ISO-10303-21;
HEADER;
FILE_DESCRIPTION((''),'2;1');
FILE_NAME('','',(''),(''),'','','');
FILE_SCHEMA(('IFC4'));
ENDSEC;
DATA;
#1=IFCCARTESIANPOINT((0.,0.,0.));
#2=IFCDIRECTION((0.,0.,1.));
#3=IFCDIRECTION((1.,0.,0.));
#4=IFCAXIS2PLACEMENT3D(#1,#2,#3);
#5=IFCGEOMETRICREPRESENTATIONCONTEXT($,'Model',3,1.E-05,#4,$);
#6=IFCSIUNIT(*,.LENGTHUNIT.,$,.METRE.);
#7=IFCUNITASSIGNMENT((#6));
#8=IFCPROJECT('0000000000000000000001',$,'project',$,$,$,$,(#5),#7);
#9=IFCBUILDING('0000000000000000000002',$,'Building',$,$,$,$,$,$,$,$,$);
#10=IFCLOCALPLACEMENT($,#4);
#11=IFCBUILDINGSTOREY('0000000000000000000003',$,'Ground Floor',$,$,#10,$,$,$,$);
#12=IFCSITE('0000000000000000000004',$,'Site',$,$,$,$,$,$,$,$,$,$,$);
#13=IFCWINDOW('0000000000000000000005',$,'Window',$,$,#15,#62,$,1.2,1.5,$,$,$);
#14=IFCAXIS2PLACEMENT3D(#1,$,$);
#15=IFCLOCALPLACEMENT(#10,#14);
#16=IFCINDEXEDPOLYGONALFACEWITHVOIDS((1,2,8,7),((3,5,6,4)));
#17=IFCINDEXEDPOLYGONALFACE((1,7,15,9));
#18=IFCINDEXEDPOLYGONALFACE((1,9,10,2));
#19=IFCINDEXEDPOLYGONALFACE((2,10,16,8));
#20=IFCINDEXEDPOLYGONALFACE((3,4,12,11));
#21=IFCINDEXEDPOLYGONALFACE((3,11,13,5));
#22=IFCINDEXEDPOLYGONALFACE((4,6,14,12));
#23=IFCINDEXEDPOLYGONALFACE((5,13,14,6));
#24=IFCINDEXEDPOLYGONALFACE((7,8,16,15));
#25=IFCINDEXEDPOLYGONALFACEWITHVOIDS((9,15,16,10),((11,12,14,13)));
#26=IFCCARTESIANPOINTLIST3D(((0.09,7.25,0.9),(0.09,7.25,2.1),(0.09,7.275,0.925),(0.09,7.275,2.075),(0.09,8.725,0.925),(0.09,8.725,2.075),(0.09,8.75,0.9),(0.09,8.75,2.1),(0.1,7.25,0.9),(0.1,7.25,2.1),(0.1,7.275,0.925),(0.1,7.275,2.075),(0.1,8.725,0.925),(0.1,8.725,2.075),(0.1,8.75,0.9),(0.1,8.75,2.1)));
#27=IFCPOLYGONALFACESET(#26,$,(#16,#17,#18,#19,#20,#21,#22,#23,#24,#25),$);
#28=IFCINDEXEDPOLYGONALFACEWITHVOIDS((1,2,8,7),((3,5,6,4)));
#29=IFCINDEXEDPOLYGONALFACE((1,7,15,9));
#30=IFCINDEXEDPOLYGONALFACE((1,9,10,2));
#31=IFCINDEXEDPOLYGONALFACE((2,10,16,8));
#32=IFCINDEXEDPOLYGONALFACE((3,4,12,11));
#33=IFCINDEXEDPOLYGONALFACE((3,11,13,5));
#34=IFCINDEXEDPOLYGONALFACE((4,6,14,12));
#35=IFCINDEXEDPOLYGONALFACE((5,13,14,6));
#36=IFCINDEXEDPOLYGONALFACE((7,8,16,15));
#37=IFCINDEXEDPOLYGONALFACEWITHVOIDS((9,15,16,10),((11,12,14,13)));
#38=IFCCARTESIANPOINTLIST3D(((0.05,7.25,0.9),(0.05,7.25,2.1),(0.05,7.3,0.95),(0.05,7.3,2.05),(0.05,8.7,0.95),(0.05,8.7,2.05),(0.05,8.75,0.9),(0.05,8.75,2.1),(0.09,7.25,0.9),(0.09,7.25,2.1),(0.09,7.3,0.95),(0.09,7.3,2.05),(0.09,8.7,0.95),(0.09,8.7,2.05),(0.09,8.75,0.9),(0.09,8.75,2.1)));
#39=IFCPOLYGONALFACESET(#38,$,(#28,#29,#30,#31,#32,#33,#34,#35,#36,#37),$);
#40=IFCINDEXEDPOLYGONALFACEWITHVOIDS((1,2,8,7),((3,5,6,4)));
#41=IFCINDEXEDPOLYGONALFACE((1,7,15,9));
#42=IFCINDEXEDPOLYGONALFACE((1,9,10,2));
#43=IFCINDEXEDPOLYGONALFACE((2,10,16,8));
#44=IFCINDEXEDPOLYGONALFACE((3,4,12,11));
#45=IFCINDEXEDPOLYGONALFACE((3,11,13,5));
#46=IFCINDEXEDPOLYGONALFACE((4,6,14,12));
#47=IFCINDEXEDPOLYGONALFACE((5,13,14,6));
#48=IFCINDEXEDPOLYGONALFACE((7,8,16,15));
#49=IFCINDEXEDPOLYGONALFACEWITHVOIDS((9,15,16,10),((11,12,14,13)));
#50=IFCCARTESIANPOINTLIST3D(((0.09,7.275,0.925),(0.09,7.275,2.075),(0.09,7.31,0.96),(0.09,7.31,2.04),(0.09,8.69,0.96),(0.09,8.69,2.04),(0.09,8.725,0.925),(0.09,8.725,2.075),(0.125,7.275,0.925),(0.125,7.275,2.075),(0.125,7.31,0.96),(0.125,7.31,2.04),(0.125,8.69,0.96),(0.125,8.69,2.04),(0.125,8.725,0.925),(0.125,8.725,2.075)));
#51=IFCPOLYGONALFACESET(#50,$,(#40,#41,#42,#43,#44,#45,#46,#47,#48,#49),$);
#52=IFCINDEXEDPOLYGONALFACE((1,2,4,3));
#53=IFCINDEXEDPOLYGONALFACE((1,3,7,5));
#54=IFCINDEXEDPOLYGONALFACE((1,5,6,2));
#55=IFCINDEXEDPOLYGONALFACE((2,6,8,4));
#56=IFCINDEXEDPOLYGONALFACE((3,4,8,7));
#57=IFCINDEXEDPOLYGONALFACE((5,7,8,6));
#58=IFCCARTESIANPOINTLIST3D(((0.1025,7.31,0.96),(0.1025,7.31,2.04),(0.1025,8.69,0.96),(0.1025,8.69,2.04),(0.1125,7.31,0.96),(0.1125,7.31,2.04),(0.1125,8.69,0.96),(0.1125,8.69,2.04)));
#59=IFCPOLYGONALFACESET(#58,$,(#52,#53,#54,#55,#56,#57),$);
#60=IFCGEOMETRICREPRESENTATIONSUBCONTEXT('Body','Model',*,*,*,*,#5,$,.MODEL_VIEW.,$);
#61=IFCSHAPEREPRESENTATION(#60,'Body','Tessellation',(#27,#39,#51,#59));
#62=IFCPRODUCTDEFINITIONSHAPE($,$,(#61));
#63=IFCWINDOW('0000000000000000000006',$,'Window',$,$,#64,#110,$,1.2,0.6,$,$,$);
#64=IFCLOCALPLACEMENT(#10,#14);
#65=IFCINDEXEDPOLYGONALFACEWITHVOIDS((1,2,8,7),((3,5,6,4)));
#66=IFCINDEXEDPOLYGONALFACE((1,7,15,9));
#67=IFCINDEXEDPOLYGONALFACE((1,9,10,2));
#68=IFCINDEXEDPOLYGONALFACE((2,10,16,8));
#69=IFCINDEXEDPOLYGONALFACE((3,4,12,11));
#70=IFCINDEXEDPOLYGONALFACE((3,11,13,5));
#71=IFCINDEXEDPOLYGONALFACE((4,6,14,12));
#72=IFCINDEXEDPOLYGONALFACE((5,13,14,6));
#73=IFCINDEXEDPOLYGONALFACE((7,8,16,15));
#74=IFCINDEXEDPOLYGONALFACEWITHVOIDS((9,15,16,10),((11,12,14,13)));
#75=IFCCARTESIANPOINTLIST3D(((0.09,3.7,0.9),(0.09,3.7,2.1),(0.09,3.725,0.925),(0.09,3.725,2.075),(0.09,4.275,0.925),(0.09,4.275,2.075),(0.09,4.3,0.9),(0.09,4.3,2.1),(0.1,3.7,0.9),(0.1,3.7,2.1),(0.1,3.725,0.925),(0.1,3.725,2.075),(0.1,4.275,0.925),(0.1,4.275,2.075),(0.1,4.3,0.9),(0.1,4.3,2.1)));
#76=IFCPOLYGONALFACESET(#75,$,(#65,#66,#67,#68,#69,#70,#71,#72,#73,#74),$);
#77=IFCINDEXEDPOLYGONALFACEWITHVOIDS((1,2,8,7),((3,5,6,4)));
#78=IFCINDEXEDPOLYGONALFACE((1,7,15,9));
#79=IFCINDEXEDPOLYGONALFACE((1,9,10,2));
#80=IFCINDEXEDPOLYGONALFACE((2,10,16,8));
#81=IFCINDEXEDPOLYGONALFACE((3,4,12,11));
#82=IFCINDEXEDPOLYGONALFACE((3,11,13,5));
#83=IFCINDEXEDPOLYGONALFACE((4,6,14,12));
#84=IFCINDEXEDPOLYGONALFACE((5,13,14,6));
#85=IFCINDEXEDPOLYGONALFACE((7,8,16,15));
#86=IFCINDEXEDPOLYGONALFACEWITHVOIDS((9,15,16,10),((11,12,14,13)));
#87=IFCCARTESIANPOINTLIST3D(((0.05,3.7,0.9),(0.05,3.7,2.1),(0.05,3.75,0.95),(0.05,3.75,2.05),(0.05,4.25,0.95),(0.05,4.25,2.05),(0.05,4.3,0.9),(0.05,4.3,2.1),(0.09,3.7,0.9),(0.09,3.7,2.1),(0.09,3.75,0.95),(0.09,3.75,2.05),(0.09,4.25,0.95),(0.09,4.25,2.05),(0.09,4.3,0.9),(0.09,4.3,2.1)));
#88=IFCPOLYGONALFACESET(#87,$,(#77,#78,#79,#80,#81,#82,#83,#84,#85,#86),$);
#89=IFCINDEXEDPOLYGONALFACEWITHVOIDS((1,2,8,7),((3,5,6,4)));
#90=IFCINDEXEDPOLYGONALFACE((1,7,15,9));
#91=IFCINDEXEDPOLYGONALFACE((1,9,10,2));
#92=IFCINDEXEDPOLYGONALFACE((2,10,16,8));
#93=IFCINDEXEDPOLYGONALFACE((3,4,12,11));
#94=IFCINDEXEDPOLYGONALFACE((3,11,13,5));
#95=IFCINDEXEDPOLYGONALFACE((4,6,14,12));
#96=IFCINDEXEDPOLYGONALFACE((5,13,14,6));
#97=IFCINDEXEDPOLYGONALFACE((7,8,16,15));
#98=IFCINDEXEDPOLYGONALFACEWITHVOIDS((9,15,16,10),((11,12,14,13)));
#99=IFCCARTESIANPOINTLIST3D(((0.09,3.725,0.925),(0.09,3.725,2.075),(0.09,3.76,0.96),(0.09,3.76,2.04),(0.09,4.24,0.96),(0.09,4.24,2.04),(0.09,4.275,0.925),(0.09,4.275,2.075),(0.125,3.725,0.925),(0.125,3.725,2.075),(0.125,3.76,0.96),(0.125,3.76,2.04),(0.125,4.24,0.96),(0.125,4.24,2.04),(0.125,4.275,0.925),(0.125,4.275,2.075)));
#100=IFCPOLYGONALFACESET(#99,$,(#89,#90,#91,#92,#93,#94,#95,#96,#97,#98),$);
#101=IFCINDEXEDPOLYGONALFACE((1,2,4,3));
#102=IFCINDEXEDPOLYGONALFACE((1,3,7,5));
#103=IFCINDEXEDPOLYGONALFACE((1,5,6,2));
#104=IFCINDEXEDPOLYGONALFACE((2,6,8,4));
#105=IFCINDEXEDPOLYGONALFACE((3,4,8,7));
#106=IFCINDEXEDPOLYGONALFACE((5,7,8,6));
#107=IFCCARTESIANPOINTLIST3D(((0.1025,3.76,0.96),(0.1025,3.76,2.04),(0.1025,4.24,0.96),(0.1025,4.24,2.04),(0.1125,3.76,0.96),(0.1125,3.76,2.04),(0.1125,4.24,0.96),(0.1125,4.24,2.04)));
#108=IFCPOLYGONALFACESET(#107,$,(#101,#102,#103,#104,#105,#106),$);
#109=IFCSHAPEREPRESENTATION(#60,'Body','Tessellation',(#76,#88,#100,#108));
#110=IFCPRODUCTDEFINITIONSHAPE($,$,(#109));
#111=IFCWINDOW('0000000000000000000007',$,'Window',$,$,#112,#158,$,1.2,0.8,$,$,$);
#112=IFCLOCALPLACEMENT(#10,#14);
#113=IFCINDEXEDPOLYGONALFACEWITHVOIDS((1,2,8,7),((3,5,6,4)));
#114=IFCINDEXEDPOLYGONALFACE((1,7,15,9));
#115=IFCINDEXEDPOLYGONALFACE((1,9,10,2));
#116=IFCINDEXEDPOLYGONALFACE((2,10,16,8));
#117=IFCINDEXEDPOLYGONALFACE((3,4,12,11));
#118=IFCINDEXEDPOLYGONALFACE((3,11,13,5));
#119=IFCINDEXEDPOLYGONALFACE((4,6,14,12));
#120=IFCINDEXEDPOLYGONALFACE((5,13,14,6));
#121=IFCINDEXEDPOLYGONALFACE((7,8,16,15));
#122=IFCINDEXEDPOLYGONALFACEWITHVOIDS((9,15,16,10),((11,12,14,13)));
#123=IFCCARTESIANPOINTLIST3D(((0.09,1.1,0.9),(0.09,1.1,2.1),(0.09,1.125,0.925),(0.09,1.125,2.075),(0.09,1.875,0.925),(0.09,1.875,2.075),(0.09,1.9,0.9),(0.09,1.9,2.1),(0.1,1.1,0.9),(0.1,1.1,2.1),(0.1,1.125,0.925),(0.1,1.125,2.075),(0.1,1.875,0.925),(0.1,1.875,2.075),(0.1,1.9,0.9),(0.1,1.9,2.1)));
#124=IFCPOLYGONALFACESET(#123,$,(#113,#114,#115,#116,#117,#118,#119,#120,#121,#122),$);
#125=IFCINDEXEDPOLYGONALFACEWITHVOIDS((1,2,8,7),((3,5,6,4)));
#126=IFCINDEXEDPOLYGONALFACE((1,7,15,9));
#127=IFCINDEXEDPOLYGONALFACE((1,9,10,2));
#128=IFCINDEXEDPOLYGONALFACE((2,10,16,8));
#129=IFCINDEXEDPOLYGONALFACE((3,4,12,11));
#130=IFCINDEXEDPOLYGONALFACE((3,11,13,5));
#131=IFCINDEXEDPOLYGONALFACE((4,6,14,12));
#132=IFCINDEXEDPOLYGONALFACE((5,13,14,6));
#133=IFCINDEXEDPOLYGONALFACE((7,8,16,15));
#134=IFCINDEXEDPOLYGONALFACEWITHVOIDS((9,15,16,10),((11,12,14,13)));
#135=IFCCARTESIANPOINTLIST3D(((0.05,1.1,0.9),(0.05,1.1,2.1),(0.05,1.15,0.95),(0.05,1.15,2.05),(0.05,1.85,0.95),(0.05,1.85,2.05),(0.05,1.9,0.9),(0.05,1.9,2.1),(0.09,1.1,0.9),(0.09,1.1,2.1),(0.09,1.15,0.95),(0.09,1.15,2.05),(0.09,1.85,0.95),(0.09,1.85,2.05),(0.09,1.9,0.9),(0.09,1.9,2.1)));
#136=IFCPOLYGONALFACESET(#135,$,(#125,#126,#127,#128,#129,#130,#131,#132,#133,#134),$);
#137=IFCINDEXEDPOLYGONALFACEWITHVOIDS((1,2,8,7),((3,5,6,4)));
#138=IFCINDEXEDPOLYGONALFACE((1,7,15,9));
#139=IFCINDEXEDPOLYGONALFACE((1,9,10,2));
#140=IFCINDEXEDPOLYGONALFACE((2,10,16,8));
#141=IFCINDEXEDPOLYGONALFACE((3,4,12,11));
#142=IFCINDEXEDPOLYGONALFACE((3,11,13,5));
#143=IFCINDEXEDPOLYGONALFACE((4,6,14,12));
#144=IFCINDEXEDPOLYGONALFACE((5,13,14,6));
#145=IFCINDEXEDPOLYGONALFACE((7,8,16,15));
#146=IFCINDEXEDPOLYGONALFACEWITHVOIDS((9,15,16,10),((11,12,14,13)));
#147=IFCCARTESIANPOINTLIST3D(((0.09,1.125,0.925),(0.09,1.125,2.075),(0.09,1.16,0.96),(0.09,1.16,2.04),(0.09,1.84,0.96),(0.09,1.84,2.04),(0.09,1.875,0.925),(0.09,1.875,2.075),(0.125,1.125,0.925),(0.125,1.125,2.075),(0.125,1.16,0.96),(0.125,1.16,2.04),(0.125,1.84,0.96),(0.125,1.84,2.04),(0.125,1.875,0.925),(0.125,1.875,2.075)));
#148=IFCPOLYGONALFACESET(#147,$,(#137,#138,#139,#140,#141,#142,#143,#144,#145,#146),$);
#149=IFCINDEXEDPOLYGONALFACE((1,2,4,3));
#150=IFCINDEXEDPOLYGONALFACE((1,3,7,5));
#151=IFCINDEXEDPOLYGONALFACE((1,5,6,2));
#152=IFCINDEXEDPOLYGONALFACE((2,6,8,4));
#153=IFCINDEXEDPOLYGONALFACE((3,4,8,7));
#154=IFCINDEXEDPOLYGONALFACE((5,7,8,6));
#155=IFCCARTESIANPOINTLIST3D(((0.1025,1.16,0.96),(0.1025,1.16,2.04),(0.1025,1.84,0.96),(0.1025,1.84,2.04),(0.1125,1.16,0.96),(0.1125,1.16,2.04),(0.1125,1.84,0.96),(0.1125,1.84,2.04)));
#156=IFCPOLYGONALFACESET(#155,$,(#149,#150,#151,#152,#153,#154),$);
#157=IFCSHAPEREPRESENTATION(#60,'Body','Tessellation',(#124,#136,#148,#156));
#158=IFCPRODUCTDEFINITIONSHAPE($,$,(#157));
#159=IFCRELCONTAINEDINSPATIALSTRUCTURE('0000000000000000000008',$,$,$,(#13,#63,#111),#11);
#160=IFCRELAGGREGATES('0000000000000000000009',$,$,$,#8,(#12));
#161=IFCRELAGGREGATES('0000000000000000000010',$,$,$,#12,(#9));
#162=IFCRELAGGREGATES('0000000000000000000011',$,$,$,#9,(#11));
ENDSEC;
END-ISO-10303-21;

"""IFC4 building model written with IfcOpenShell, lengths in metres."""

from ifc_helpers import new_model, si_unit, frame, origin_with_axes, place, context, subcontext, project, spatial, line, indexed_curve, outline, extrude, element, save


model = new_model("IFC4")

# Units and contexts
model_context = context("Model", 3, precision=1e-05, world=origin_with_axes())
body_context = subcontext(model_context, "Body", "Model", "MODEL_VIEW")
ifc_project = project(units=[si_unit("LENGTHUNIT", "METRE")], contexts=[model_context])

# Site, building, storey
site = spatial("IfcSite", under=ifc_project, Name="Site")
building = spatial("IfcBuilding", under=site, Name="Building")
storey_placement = place(None, origin_with_axes())
storey = spatial("IfcBuildingStorey", under=building, at=storey_placement, Name="Ground Floor")

# Windows
window_1_placement = place(storey_placement, frame((0.0, 8.75, 0.9), z_axis=(0.0, 0.0, 1.0), x_axis=(0.0, -1.0, 0.0)))
element("IfcWindow", 1, at=window_1_placement, inside=storey, Name="Window", OverallHeight=1.2, OverallWidth=1.5, context=body_context, shape_type="SweptSolid", body=[
    extrude(outline(indexed_curve([(0.0, 0.0), (1.5, 0.0), (1.5, 1.2), (0.0, 1.2)], segments=[line(1, 2, 3, 4, 1)]), holes=[indexed_curve([(0.025, 0.025), (1.475, 0.025), (1.475, 1.175), (0.025, 1.175)], segments=[line(1, 2, 3, 4, 1)])]), frame((0.0, 0.09, 0.0), z_axis=(0.0, -1.0, 0.0), x_axis=(1.0, 0.0, 0.0)), (0.0, 0.0, -1.0), 0.01),
    extrude(outline(indexed_curve([(0.0, 0.0), (1.5, 0.0), (1.5, 1.2), (0.0, 1.2)], segments=[line(1, 2, 3, 4, 1)]), holes=[indexed_curve([(0.05, 0.05), (1.45, 0.05), (1.45, 1.15), (0.05, 1.15)], segments=[line(1, 2, 3, 4, 1)])]), frame((0.0, 0.05, 0.0), z_axis=(0.0, -1.0, 0.0), x_axis=(1.0, 0.0, 0.0)), (0.0, 0.0, -1.0), 0.04),
    extrude(outline(indexed_curve([(0.0, 0.0), (1.45, 0.0), (1.45, 1.15), (0.0, 1.15)], segments=[line(1, 2, 3, 4, 1)]), holes=[indexed_curve([(0.035, 0.035), (1.415, 0.035), (1.415, 1.115), (0.035, 1.115)], segments=[line(1, 2, 3, 4, 1)])]), frame((0.025, 0.09, 0.025), z_axis=(0.0, -1.0, 0.0), x_axis=(1.0, 0.0, 0.0)), (0.0, 0.0, -1.0), 0.035),
    extrude(outline(indexed_curve([(0.035, 0.035), (1.415, 0.035), (1.415, 1.115), (0.035, 1.115)], segments=[line(1, 2, 3, 4, 1)])), frame((0.025, 0.1025, 0.025), z_axis=(0.0, -1.0, 0.0), x_axis=(1.0, 0.0, 0.0)), (0.0, 0.0, -1.0), 0.01),
])
window_2_placement = place(storey_placement, frame((0.0, 4.3, 0.9), z_axis=(0.0, 0.0, 1.0), x_axis=(0.0, -1.0, 0.0)))
element("IfcWindow", 2, at=window_2_placement, inside=storey, Name="Window", OverallHeight=1.2, OverallWidth=0.6, context=body_context, shape_type="SweptSolid", body=[
    extrude(outline(indexed_curve([(0.0, 0.0), (0.6, 0.0), (0.6, 1.2), (0.0, 1.2)], segments=[line(1, 2, 3, 4, 1)]), holes=[indexed_curve([(0.025, 0.025), (0.575, 0.025), (0.575, 1.175), (0.025, 1.175)], segments=[line(1, 2, 3, 4, 1)])]), frame((0.0, 0.09, 0.0), z_axis=(0.0, -1.0, 0.0), x_axis=(1.0, 0.0, 0.0)), (0.0, 0.0, -1.0), 0.01),
    extrude(outline(indexed_curve([(0.0, 0.0), (0.6, 0.0), (0.6, 1.2), (0.0, 1.2)], segments=[line(1, 2, 3, 4, 1)]), holes=[indexed_curve([(0.05, 0.05), (0.55, 0.05), (0.55, 1.15), (0.05, 1.15)], segments=[line(1, 2, 3, 4, 1)])]), frame((0.0, 0.05, 0.0), z_axis=(0.0, -1.0, 0.0), x_axis=(1.0, 0.0, 0.0)), (0.0, 0.0, -1.0), 0.04),
    extrude(outline(indexed_curve([(0.0, 0.0), (0.55, 0.0), (0.55, 1.15), (0.0, 1.15)], segments=[line(1, 2, 3, 4, 1)]), holes=[indexed_curve([(0.035, 0.035), (0.515, 0.035), (0.515, 1.115), (0.035, 1.115)], segments=[line(1, 2, 3, 4, 1)])]), frame((0.025, 0.09, 0.025), z_axis=(0.0, -1.0, 0.0), x_axis=(1.0, 0.0, 0.0)), (0.0, 0.0, -1.0), 0.035),
    extrude(outline(indexed_curve([(0.035, 0.035), (0.515, 0.035), (0.515, 1.115), (0.035, 1.115)], segments=[line(1, 2, 3, 4, 1)])), frame((0.025, 0.1025, 0.025), z_axis=(0.0, -1.0, 0.0), x_axis=(1.0, 0.0, 0.0)), (0.0, 0.0, -1.0), 0.01),
])
window_3_placement = place(storey_placement, frame((0.0, 1.9, 0.9), z_axis=(0.0, 0.0, 1.0), x_axis=(0.0, -1.0, 0.0)))
element("IfcWindow", 3, at=window_3_placement, inside=storey, Name="Window", OverallHeight=1.2, OverallWidth=0.8, context=body_context, shape_type="SweptSolid", body=[
    extrude(outline(indexed_curve([(0.0, 0.0), (0.8, 0.0), (0.8, 1.2), (0.0, 1.2)], segments=[line(1, 2, 3, 4, 1)]), holes=[indexed_curve([(0.025, 0.025), (0.775, 0.025), (0.775, 1.175), (0.025, 1.175)], segments=[line(1, 2, 3, 4, 1)])]), frame((0.0, 0.09, 0.0), z_axis=(0.0, -1.0, 0.0), x_axis=(1.0, 0.0, 0.0)), (0.0, 0.0, -1.0), 0.01),
    extrude(outline(indexed_curve([(0.0, 0.0), (0.8, 0.0), (0.8, 1.2), (0.0, 1.2)], segments=[line(1, 2, 3, 4, 1)]), holes=[indexed_curve([(0.05, 0.05), (0.75, 0.05), (0.75, 1.15), (0.05, 1.15)], segments=[line(1, 2, 3, 4, 1)])]), frame((0.0, 0.05, 0.0), z_axis=(0.0, -1.0, 0.0), x_axis=(1.0, 0.0, 0.0)), (0.0, 0.0, -1.0), 0.04),
    extrude(outline(indexed_curve([(0.0, 0.0), (0.75, 0.0), (0.75, 1.15), (0.0, 1.15)], segments=[line(1, 2, 3, 4, 1)]), holes=[indexed_curve([(0.035, 0.035), (0.715, 0.035), (0.715, 1.115), (0.035, 1.115)], segments=[line(1, 2, 3, 4, 1)])]), frame((0.025, 0.09, 0.025), z_axis=(0.0, -1.0, 0.0), x_axis=(1.0, 0.0, 0.0)), (0.0, 0.0, -1.0), 0.035),
    extrude(outline(indexed_curve([(0.035, 0.035), (0.715, 0.035), (0.715, 1.115), (0.035, 1.115)], segments=[line(1, 2, 3, 4, 1)])), frame((0.025, 0.1025, 0.025), z_axis=(0.0, -1.0, 0.0), x_axis=(1.0, 0.0, 0.0)), (0.0, 0.0, -1.0), 0.01),
])

save(model, "model.ifc")
